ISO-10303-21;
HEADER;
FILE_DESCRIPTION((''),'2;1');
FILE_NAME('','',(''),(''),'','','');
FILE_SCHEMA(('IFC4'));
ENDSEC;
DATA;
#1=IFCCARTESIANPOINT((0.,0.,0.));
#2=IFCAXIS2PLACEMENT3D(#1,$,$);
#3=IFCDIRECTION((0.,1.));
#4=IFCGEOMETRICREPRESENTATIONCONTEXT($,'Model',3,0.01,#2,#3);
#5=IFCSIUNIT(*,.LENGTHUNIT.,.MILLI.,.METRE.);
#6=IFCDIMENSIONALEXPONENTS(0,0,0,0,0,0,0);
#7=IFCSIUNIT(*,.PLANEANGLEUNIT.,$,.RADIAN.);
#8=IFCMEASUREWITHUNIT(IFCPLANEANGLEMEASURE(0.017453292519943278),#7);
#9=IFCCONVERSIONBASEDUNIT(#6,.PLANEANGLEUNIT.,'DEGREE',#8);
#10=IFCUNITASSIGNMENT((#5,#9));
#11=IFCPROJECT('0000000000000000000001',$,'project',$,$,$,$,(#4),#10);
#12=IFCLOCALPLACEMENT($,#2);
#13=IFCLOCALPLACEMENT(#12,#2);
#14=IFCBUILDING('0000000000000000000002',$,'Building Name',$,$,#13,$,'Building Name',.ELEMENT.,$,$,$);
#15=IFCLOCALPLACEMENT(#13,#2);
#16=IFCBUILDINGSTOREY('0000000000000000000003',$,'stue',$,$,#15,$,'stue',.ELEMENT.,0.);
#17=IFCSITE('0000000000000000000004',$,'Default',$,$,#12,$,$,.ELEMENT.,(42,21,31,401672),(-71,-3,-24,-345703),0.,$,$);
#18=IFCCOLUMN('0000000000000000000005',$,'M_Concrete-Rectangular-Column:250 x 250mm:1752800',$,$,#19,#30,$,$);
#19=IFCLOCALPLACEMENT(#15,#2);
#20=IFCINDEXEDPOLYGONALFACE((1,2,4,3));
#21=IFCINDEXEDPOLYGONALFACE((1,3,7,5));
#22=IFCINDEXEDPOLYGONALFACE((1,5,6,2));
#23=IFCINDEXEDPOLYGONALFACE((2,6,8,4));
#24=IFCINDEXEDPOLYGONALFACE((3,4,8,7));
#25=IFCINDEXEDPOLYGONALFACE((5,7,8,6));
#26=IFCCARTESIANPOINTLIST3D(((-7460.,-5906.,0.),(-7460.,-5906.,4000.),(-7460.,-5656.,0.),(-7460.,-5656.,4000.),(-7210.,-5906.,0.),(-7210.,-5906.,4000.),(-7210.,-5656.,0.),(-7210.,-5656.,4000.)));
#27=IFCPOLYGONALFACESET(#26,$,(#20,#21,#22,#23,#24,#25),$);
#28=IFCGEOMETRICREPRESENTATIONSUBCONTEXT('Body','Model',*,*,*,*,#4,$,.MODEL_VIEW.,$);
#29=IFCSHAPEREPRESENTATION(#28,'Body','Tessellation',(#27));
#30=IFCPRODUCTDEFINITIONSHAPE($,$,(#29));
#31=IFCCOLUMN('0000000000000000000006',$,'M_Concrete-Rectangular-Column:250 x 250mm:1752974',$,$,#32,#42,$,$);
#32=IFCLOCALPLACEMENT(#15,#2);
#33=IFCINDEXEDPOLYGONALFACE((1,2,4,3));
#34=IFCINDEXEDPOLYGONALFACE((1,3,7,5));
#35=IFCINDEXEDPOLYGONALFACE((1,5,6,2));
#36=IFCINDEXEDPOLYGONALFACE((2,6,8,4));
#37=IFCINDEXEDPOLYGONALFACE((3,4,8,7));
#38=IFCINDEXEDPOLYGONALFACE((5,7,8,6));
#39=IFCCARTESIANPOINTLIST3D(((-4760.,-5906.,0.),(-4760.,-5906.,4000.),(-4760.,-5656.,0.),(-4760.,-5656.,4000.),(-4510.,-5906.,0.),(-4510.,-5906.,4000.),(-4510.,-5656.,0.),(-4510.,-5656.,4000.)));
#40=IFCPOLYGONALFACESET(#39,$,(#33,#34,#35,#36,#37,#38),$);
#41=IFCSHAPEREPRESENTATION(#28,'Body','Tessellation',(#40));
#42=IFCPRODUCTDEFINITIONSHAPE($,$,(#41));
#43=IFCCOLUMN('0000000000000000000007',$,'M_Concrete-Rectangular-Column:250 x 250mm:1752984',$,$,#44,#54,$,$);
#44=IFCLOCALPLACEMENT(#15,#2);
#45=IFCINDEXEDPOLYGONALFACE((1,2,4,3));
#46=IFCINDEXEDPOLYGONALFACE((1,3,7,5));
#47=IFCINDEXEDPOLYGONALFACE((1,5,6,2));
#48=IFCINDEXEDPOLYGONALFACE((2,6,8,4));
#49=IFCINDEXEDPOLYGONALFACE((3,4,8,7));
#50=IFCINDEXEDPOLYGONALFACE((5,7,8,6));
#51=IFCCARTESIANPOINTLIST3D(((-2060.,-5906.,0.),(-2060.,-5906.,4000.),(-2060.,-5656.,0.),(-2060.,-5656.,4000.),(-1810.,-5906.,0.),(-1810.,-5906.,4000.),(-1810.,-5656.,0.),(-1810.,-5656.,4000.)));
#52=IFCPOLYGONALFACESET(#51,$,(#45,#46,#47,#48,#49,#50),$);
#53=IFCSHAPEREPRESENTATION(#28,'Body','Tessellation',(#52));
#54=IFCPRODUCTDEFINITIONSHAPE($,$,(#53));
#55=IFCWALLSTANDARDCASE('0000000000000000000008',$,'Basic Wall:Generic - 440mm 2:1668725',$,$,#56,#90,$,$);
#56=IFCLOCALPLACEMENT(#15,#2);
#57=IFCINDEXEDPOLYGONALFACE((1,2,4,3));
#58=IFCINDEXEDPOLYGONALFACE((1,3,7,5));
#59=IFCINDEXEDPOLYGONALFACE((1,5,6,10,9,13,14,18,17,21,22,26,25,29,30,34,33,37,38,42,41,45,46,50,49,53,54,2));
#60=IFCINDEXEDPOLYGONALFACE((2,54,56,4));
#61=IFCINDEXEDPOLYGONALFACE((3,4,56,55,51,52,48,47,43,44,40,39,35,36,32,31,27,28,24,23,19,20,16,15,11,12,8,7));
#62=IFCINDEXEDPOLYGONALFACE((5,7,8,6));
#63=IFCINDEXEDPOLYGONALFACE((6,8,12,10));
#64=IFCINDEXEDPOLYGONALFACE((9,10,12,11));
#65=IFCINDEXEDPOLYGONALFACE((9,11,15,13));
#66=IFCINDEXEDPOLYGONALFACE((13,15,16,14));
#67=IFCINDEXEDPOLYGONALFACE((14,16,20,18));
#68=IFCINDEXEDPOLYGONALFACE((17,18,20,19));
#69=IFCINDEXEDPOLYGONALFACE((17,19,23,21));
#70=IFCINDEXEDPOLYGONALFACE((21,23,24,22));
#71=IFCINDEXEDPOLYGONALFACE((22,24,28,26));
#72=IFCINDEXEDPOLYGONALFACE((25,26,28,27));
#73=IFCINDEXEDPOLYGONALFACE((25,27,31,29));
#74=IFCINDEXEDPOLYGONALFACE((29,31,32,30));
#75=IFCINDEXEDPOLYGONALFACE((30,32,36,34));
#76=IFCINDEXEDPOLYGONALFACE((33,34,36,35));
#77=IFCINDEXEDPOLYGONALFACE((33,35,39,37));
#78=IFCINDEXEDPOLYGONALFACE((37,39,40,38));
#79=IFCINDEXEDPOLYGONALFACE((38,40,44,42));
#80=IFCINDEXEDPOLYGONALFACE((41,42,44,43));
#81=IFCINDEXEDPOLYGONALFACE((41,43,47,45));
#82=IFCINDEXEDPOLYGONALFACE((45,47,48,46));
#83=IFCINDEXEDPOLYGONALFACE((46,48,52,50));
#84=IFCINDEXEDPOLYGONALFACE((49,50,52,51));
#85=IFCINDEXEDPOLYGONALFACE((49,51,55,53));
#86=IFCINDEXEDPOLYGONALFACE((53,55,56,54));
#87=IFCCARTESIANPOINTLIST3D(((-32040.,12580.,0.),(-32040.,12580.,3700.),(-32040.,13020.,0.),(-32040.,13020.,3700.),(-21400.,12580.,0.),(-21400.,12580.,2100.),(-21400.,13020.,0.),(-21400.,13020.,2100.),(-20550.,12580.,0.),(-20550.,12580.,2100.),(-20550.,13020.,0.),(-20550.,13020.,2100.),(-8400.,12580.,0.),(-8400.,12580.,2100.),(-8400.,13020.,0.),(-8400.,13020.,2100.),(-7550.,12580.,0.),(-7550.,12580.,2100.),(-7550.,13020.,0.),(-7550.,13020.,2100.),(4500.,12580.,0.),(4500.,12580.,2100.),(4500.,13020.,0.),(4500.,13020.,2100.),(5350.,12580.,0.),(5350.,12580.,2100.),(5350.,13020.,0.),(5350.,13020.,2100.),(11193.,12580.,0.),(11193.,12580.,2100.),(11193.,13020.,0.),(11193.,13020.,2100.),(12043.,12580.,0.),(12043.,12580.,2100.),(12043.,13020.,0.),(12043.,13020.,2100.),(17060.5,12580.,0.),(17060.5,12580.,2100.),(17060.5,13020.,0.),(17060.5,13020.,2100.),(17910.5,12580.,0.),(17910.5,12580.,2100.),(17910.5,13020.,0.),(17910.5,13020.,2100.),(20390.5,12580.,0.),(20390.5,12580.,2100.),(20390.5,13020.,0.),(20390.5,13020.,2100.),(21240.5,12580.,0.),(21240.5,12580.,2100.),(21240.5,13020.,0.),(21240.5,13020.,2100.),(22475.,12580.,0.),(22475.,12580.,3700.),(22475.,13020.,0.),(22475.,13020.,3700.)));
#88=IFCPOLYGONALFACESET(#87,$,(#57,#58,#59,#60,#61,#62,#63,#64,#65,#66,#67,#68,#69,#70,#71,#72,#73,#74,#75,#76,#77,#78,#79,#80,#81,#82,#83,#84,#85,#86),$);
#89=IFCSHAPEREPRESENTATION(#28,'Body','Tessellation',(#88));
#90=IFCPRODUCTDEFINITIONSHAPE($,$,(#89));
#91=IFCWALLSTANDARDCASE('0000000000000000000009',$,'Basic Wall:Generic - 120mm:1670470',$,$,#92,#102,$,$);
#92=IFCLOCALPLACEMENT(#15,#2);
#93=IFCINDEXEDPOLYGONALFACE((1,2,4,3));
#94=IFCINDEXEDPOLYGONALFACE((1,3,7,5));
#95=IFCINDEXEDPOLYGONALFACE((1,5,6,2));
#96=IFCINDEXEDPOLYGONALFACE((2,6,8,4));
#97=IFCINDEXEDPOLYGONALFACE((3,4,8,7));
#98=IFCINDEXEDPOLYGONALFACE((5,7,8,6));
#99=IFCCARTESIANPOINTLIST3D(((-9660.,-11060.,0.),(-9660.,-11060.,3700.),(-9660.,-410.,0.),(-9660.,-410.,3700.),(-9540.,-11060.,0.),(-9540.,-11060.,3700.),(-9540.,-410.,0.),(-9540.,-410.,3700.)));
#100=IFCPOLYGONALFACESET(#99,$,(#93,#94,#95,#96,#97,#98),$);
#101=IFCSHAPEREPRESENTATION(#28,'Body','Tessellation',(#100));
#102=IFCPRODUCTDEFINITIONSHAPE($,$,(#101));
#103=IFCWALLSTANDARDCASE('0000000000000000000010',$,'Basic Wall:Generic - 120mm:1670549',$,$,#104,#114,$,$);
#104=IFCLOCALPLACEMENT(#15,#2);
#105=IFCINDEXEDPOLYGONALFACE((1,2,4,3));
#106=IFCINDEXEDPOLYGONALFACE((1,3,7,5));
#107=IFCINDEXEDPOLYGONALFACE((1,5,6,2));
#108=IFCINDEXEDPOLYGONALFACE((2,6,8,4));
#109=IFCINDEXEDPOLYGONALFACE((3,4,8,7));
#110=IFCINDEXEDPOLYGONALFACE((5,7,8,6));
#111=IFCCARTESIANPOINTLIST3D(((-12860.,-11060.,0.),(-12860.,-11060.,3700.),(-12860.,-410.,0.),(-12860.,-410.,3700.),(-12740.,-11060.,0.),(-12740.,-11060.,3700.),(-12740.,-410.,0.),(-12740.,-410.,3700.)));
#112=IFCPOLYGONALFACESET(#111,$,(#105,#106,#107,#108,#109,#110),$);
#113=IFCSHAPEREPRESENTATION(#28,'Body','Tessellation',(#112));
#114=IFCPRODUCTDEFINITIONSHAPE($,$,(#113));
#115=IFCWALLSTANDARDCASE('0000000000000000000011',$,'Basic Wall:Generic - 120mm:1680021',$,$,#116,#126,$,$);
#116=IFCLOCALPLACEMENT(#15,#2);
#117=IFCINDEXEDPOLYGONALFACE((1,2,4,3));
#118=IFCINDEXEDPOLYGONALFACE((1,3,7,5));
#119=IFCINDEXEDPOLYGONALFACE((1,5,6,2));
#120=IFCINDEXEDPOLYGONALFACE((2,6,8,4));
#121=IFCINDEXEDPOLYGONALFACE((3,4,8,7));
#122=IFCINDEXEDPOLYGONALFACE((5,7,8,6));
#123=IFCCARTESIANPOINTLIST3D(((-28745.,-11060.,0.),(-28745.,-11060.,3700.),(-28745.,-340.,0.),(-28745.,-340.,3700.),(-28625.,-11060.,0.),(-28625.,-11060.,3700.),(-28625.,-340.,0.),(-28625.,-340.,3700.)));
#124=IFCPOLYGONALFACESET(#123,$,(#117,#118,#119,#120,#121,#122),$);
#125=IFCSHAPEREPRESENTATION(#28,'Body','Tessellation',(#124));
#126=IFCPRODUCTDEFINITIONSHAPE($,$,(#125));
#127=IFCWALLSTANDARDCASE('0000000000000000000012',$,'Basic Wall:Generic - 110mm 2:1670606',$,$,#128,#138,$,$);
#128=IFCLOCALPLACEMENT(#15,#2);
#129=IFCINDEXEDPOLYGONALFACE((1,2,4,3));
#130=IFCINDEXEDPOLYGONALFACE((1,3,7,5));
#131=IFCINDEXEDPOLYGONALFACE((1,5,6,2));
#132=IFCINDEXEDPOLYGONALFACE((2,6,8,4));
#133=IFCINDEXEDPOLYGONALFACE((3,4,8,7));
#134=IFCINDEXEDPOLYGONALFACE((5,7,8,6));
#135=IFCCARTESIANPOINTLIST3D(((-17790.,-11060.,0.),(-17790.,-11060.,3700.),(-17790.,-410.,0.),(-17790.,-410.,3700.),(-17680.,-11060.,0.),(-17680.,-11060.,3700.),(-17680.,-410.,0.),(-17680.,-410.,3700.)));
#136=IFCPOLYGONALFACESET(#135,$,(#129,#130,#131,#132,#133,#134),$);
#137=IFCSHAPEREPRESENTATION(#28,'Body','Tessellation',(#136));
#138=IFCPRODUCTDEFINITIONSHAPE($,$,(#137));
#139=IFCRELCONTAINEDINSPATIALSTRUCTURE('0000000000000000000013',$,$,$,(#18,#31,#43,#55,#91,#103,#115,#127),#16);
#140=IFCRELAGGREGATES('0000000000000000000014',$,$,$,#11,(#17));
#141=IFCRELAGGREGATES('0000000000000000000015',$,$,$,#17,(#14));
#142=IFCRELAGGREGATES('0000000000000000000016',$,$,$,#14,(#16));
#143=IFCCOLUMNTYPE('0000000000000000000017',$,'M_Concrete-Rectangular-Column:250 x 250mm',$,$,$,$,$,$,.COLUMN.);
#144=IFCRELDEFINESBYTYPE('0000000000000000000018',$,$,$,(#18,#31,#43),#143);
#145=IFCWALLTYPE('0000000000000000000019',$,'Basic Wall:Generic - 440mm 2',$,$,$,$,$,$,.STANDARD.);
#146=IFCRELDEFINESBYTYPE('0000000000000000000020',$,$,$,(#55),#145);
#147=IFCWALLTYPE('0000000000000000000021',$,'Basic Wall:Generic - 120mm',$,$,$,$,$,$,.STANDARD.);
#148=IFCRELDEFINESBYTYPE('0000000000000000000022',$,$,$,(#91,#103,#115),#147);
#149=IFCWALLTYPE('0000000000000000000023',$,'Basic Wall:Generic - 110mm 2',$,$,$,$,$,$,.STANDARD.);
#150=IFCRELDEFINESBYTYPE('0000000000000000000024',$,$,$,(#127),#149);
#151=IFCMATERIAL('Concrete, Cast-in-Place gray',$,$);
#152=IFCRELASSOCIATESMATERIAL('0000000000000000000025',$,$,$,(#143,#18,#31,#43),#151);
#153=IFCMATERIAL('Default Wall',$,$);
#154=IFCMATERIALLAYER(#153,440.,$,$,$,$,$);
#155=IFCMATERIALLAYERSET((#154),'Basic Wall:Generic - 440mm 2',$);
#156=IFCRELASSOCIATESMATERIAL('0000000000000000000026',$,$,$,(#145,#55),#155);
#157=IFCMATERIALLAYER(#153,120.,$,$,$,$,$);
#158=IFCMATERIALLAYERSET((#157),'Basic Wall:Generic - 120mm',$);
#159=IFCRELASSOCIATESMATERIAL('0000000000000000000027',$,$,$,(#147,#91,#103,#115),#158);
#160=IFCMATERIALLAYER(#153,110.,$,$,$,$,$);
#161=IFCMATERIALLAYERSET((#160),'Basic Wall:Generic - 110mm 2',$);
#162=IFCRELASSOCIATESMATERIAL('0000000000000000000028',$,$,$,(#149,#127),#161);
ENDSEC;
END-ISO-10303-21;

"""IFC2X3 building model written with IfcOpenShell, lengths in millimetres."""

from ifc_helpers import new_model, entity, si_unit, converted_unit, direction, frame, frame_2d, origin, origin_2d_with_axis, place, context, subcontext, project, spatial, polyline, rectangle, extrude, clip, bounded_halfspace, source, transform, mapped, material, layer, layer_set, layer_usage, type_object, type_shapes, element, save


model = new_model("IFC2X3")

# Units and contexts
model_context = context("Model", 3, precision=0.01, world=origin(), true_north=direction((0.0, 1.0)))
body_context = subcontext(model_context, "Body", "Model", "MODEL_VIEW")
ifc_project = project(units=[si_unit("LENGTHUNIT", "METRE", prefix="MILLI"), converted_unit("PLANEANGLEUNIT", "DEGREE", entity("IfcPlaneAngleMeasure", 0.017453292519943278), si_unit("PLANEANGLEUNIT", "RADIAN"), dimensions=[0, 0, 0, 0, 0, 0, 0])], contexts=[model_context])

# Site, building, storey
site_placement = place(None, origin())
site = spatial("IfcSite", under=ifc_project, at=site_placement, Name="Default", CompositionType="ELEMENT", RefLatitude=(42, 21, 31, 401672), RefLongitude=(-71, -3, -24, -345703), RefElevation=0.0)
building_placement = place(site_placement, origin())
building = spatial("IfcBuilding", under=site, at=building_placement, Name="Building Name", LongName="Building Name", CompositionType="ELEMENT")
storey_placement = place(building_placement, origin())
storey = spatial("IfcBuildingStorey", under=building, at=storey_placement, Name="stue", LongName="stue", CompositionType="ELEMENT", Elevation=0.0)

# Columns
ifc_material_1 = material(Name="Concrete, Cast-in-Place gray")
column_type = type_object("IfcColumnType", Name="M_Concrete-Rectangular-Column:250 x 250mm", PredefinedType="COLUMN", material=ifc_material_1)
shared_shape_1 = source(origin(), body_context, "Body", "SweptSolid", [
    extrude(rectangle(XDim=250.0, YDim=250.0, at=origin_2d_with_axis()), frame((0.0, 0.0, 0.0), z_axis=(0.0, 0.0, 1.0), x_axis=(-1.0, 0.0, 0.0)), (0.0, 0.0, 1.0), 4000.0),
])
type_shapes(column_type, [shared_shape_1])
for number, where, name in (
    (1, (-7335.0, -5781.0, 0.0), "M_Concrete-Rectangular-Column:250 x 250mm:1752800"),
    (2, (-4635.0, -5781.0, 0.0), "M_Concrete-Rectangular-Column:250 x 250mm:1752974"),
    (3, (-1935.0, -5781.0, 0.0), "M_Concrete-Rectangular-Column:250 x 250mm:1752984"),
):
    element("IfcColumn", number, at=place(storey_placement, frame(where)), inside=storey, type_object=column_type, material=ifc_material_1, Name=name, context=body_context, shape_type="MappedRepresentation", body=[
        mapped(shared_shape_1, transform((0.0, 0.0, 0.0), scale=1.0)),
    ])

# Wall, openings
ifc_material_2 = material(Name="Default Wall")
ifc_layer_1 = layer(ifc_material_2, 440.0)
ifc_layer_set_1 = layer_set([ifc_layer_1], Name="Basic Wall:Generic - 440mm 2")
ifc_layer_usage_1 = layer_usage(ifc_layer_set_1, "AXIS2", "NEGATIVE", 220.0)
wall_type_1 = type_object("IfcWallType", Name="Basic Wall:Generic - 440mm 2", PredefinedType="STANDARD", material=ifc_layer_set_1)
wall_1_placement = place(storey_placement, frame((-32040.0, 12800.0, 0.0)))
wall_1 = element("IfcWallStandardCase", 4, at=wall_1_placement, inside=storey, type_object=wall_type_1, material=ifc_layer_usage_1, Name="Basic Wall:Generic - 440mm 2:1668725", context=body_context, shape_type="Clipping", body=[
    clip(extrude(rectangle(XDim=54515.0, YDim=440.0, at=frame_2d((27257.5, 0.0), x_axis=(-1.0, 0.0))), origin(), (0.0, 0.0, 1.0), 3700.0), bounded_halfspace(frame((0.0, -220.0, 3700.0), z_axis=(0.0, 0.0, -1.0), x_axis=(0.0, -1.0, 0.0)), True, frame((0.0, -220.0, 3700.0)), polyline([(0.0, 0.0), (54515.0, 0.0), (54515.0, 440.0), (54365.0, 440.0), (52230.5, 440.0), (52120.5, 440.0), (50360.5, 440.0), (50250.5, 440.0), (46971.0, 440.0), (46861.0, 440.0), (44915.0, 440.0), (44765.0, 440.0), (38515.0, 440.0), (38365.0, 440.0), (25715.0, 440.0), (25565.0, 440.0), (12915.0, 440.0), (12765.0, 440.0), (0.0, 440.0), (0.0, 0.0)]))),
])
opening_1_placement = place(wall_1_placement, frame((10640.0, -220.0, 0.0)))
element("IfcOpeningElement", 5, at=opening_1_placement, cuts=wall_1, ObjectType="Opening", context=body_context, shape_type="SweptSolid", body=[
    extrude(rectangle(XDim=2100.0, YDim=850.0, at=frame_2d((1050.0, 425.0), x_axis=(1.0, 0.0))), frame((0.0, 0.0, 0.0), z_axis=(0.0, 1.0, 0.0), x_axis=(0.0, 0.0, 1.0)), (0.0, 0.0, 1.0), 440.0),
])
opening_2_placement = place(wall_1_placement, frame((23640.0, -220.0, 0.0)))
element("IfcOpeningElement", 6, at=opening_2_placement, cuts=wall_1, ObjectType="Opening", context=body_context, shape_type="SweptSolid", body=[
    extrude(rectangle(XDim=2100.0, YDim=850.0, at=frame_2d((1050.0, 425.0), x_axis=(1.0, 0.0))), frame((0.0, 0.0, 0.0), z_axis=(0.0, 1.0, 0.0), x_axis=(0.0, 0.0, 1.0)), (0.0, 0.0, 1.0), 440.0),
])
opening_3_placement = place(wall_1_placement, frame((36540.0, -220.0, 0.0)))
element("IfcOpeningElement", 7, at=opening_3_placement, cuts=wall_1, ObjectType="Opening", context=body_context, shape_type="SweptSolid", body=[
    extrude(rectangle(XDim=2100.0, YDim=850.0, at=frame_2d((1050.0, 425.0), x_axis=(1.0, 0.0))), frame((0.0, 0.0, 0.0), z_axis=(0.0, 1.0, 0.0), x_axis=(0.0, 0.0, 1.0)), (0.0, 0.0, 1.0), 440.0),
])
opening_4_placement = place(wall_1_placement, frame((43233.0, -220.0, 0.0)))
element("IfcOpeningElement", 8, at=opening_4_placement, cuts=wall_1, ObjectType="Opening", context=body_context, shape_type="SweptSolid", body=[
    extrude(rectangle(XDim=2100.0, YDim=850.0, at=frame_2d((1050.0, 425.0), x_axis=(1.0, 0.0))), frame((0.0, 0.0, 0.0), z_axis=(0.0, 1.0, 0.0), x_axis=(0.0, 0.0, 1.0)), (0.0, 0.0, 1.0), 440.0),
])
opening_5_placement = place(wall_1_placement, frame((52430.5, -220.0, 0.0)))
element("IfcOpeningElement", 9, at=opening_5_placement, cuts=wall_1, ObjectType="Opening", context=body_context, shape_type="SweptSolid", body=[
    extrude(rectangle(XDim=2100.0, YDim=850.0, at=frame_2d((1050.0, 425.0), x_axis=(1.0, 0.0))), frame((0.0, 0.0, 0.0), z_axis=(0.0, 1.0, 0.0), x_axis=(0.0, 0.0, 1.0)), (0.0, 0.0, 1.0), 440.0),
])
opening_6_placement = place(wall_1_placement, frame((49100.5, -220.0, 0.0)))
element("IfcOpeningElement", 10, at=opening_6_placement, cuts=wall_1, ObjectType="Opening", context=body_context, shape_type="SweptSolid", body=[
    extrude(rectangle(XDim=2100.0, YDim=850.0, at=frame_2d((1050.0, 425.0), x_axis=(1.0, 0.0))), frame((0.0, 0.0, 0.0), z_axis=(0.0, 1.0, 0.0), x_axis=(0.0, 0.0, 1.0)), (0.0, 0.0, 1.0), 440.0),
])

# Walls
ifc_layer_2 = layer(ifc_material_2, 120.0)
ifc_layer_set_2 = layer_set([ifc_layer_2], Name="Basic Wall:Generic - 120mm")
ifc_layer_usage_2 = layer_usage(ifc_layer_set_2, "AXIS2", "NEGATIVE", 60.0)
wall_type_2 = type_object("IfcWallType", Name="Basic Wall:Generic - 120mm", PredefinedType="STANDARD", material=ifc_layer_set_2)
wall_2_placement = place(storey_placement, frame((-9600.0, -410.0, 0.0), z_axis=(0.0, 0.0, 1.0), x_axis=(0.0, -1.0, 0.0)))
element("IfcWallStandardCase", 11, at=wall_2_placement, inside=storey, type_object=wall_type_2, material=ifc_layer_usage_2, Name="Basic Wall:Generic - 120mm:1670470", context=body_context, shape_type="Clipping", body=[
    clip(extrude(rectangle(XDim=10650.0, YDim=120.0, at=frame_2d((5325.0, 0.0), x_axis=(-1.0, 0.0))), origin(), (0.0, 0.0, 1.0), 3700.0), bounded_halfspace(frame((0.0, -60.0, 3700.0), z_axis=(0.0, 0.0, -1.0), x_axis=(1.0, 0.0, 0.0)), True, frame((0.0, -60.0, 3700.0)), polyline([(0.0, 0.0), (10650.0, 0.0), (10650.0, 120.0), (5219.0, 120.0), (5105.0, 120.0), (0.0, 120.0), (0.0, 0.0)]))),
])
ifc_layer_usage_3 = layer_usage(ifc_layer_set_2, "AXIS2", "NEGATIVE", 60.0)
wall_3_placement = place(storey_placement, frame((-12800.0, -410.0, 0.0), z_axis=(0.0, 0.0, 1.0), x_axis=(0.0, -1.0, 0.0)))
element("IfcWallStandardCase", 12, at=wall_3_placement, inside=storey, type_object=wall_type_2, material=ifc_layer_usage_3, Name="Basic Wall:Generic - 120mm:1670549", context=body_context, shape_type="Clipping", body=[
    clip(extrude(rectangle(XDim=10650.0, YDim=120.0, at=frame_2d((5325.0, 0.0), x_axis=(-1.0, 0.0))), origin(), (0.0, 0.0, 1.0), 3700.0), bounded_halfspace(frame((0.0, -60.0, 3700.0), z_axis=(0.0, 0.0, -1.0), x_axis=(1.0, 0.0, 0.0)), True, frame((0.0, -60.0, 3700.0)), polyline([(0.0, 0.0), (10650.0, 0.0), (10650.0, 120.0), (0.0, 120.0), (0.0, 0.0)]))),
])
ifc_layer_usage_4 = layer_usage(ifc_layer_set_2, "AXIS2", "NEGATIVE", 60.0)
wall_4_placement = place(storey_placement, frame((-28685.0, -340.0, 0.0), z_axis=(0.0, 0.0, 1.0), x_axis=(0.0, -1.0, 0.0)))
element("IfcWallStandardCase", 13, at=wall_4_placement, inside=storey, type_object=wall_type_2, material=ifc_layer_usage_4, Name="Basic Wall:Generic - 120mm:1680021", context=body_context, shape_type="Clipping", body=[
    clip(extrude(rectangle(XDim=10720.0, YDim=120.0, at=frame_2d((5360.0, 0.0), x_axis=(-1.0, 0.0))), origin(), (0.0, 0.0, 1.0), 3700.0), bounded_halfspace(frame((0.0, -60.0, 3700.0), z_axis=(0.0, 0.0, -1.0), x_axis=(1.0, 0.0, 0.0)), True, frame((0.0, -60.0, 3700.0)), polyline([(0.0, 0.0), (10720.0, 0.0), (10720.0, 70.0), (10720.0, 120.0), (0.0, 120.0), (0.0, 70.0), (0.0, 0.0)]))),
])
ifc_layer_3 = layer(ifc_material_2, 110.0)
ifc_layer_set_3 = layer_set([ifc_layer_3], Name="Basic Wall:Generic - 110mm 2")
ifc_layer_usage_5 = layer_usage(ifc_layer_set_3, "AXIS2", "NEGATIVE", 55.0)
wall_type_3 = type_object("IfcWallType", Name="Basic Wall:Generic - 110mm 2", PredefinedType="STANDARD", material=ifc_layer_set_3)
wall_5_placement = place(storey_placement, frame((-17735.0, -410.0, 0.0), z_axis=(0.0, 0.0, 1.0), x_axis=(0.0, -1.0, 0.0)))
element("IfcWallStandardCase", 14, at=wall_5_placement, inside=storey, type_object=wall_type_3, material=ifc_layer_usage_5, Name="Basic Wall:Generic - 110mm 2:1670606", context=body_context, shape_type="Clipping", body=[
    clip(extrude(rectangle(XDim=10650.0, YDim=110.0, at=frame_2d((5325.0, 0.0), x_axis=(-1.0, 0.0))), origin(), (0.0, 0.0, 1.0), 3700.0), bounded_halfspace(frame((0.0, -55.0, 3700.0), z_axis=(0.0, 0.0, -1.0), x_axis=(1.0, 0.0, 0.0)), True, frame((0.0, -55.0, 3700.0)), polyline([(0.0, 0.0), (10650.0, 0.0), (10650.0, 110.0), (0.0, 110.0), (0.0, 0.0)]))),
])

save(model, "model.ifc")
